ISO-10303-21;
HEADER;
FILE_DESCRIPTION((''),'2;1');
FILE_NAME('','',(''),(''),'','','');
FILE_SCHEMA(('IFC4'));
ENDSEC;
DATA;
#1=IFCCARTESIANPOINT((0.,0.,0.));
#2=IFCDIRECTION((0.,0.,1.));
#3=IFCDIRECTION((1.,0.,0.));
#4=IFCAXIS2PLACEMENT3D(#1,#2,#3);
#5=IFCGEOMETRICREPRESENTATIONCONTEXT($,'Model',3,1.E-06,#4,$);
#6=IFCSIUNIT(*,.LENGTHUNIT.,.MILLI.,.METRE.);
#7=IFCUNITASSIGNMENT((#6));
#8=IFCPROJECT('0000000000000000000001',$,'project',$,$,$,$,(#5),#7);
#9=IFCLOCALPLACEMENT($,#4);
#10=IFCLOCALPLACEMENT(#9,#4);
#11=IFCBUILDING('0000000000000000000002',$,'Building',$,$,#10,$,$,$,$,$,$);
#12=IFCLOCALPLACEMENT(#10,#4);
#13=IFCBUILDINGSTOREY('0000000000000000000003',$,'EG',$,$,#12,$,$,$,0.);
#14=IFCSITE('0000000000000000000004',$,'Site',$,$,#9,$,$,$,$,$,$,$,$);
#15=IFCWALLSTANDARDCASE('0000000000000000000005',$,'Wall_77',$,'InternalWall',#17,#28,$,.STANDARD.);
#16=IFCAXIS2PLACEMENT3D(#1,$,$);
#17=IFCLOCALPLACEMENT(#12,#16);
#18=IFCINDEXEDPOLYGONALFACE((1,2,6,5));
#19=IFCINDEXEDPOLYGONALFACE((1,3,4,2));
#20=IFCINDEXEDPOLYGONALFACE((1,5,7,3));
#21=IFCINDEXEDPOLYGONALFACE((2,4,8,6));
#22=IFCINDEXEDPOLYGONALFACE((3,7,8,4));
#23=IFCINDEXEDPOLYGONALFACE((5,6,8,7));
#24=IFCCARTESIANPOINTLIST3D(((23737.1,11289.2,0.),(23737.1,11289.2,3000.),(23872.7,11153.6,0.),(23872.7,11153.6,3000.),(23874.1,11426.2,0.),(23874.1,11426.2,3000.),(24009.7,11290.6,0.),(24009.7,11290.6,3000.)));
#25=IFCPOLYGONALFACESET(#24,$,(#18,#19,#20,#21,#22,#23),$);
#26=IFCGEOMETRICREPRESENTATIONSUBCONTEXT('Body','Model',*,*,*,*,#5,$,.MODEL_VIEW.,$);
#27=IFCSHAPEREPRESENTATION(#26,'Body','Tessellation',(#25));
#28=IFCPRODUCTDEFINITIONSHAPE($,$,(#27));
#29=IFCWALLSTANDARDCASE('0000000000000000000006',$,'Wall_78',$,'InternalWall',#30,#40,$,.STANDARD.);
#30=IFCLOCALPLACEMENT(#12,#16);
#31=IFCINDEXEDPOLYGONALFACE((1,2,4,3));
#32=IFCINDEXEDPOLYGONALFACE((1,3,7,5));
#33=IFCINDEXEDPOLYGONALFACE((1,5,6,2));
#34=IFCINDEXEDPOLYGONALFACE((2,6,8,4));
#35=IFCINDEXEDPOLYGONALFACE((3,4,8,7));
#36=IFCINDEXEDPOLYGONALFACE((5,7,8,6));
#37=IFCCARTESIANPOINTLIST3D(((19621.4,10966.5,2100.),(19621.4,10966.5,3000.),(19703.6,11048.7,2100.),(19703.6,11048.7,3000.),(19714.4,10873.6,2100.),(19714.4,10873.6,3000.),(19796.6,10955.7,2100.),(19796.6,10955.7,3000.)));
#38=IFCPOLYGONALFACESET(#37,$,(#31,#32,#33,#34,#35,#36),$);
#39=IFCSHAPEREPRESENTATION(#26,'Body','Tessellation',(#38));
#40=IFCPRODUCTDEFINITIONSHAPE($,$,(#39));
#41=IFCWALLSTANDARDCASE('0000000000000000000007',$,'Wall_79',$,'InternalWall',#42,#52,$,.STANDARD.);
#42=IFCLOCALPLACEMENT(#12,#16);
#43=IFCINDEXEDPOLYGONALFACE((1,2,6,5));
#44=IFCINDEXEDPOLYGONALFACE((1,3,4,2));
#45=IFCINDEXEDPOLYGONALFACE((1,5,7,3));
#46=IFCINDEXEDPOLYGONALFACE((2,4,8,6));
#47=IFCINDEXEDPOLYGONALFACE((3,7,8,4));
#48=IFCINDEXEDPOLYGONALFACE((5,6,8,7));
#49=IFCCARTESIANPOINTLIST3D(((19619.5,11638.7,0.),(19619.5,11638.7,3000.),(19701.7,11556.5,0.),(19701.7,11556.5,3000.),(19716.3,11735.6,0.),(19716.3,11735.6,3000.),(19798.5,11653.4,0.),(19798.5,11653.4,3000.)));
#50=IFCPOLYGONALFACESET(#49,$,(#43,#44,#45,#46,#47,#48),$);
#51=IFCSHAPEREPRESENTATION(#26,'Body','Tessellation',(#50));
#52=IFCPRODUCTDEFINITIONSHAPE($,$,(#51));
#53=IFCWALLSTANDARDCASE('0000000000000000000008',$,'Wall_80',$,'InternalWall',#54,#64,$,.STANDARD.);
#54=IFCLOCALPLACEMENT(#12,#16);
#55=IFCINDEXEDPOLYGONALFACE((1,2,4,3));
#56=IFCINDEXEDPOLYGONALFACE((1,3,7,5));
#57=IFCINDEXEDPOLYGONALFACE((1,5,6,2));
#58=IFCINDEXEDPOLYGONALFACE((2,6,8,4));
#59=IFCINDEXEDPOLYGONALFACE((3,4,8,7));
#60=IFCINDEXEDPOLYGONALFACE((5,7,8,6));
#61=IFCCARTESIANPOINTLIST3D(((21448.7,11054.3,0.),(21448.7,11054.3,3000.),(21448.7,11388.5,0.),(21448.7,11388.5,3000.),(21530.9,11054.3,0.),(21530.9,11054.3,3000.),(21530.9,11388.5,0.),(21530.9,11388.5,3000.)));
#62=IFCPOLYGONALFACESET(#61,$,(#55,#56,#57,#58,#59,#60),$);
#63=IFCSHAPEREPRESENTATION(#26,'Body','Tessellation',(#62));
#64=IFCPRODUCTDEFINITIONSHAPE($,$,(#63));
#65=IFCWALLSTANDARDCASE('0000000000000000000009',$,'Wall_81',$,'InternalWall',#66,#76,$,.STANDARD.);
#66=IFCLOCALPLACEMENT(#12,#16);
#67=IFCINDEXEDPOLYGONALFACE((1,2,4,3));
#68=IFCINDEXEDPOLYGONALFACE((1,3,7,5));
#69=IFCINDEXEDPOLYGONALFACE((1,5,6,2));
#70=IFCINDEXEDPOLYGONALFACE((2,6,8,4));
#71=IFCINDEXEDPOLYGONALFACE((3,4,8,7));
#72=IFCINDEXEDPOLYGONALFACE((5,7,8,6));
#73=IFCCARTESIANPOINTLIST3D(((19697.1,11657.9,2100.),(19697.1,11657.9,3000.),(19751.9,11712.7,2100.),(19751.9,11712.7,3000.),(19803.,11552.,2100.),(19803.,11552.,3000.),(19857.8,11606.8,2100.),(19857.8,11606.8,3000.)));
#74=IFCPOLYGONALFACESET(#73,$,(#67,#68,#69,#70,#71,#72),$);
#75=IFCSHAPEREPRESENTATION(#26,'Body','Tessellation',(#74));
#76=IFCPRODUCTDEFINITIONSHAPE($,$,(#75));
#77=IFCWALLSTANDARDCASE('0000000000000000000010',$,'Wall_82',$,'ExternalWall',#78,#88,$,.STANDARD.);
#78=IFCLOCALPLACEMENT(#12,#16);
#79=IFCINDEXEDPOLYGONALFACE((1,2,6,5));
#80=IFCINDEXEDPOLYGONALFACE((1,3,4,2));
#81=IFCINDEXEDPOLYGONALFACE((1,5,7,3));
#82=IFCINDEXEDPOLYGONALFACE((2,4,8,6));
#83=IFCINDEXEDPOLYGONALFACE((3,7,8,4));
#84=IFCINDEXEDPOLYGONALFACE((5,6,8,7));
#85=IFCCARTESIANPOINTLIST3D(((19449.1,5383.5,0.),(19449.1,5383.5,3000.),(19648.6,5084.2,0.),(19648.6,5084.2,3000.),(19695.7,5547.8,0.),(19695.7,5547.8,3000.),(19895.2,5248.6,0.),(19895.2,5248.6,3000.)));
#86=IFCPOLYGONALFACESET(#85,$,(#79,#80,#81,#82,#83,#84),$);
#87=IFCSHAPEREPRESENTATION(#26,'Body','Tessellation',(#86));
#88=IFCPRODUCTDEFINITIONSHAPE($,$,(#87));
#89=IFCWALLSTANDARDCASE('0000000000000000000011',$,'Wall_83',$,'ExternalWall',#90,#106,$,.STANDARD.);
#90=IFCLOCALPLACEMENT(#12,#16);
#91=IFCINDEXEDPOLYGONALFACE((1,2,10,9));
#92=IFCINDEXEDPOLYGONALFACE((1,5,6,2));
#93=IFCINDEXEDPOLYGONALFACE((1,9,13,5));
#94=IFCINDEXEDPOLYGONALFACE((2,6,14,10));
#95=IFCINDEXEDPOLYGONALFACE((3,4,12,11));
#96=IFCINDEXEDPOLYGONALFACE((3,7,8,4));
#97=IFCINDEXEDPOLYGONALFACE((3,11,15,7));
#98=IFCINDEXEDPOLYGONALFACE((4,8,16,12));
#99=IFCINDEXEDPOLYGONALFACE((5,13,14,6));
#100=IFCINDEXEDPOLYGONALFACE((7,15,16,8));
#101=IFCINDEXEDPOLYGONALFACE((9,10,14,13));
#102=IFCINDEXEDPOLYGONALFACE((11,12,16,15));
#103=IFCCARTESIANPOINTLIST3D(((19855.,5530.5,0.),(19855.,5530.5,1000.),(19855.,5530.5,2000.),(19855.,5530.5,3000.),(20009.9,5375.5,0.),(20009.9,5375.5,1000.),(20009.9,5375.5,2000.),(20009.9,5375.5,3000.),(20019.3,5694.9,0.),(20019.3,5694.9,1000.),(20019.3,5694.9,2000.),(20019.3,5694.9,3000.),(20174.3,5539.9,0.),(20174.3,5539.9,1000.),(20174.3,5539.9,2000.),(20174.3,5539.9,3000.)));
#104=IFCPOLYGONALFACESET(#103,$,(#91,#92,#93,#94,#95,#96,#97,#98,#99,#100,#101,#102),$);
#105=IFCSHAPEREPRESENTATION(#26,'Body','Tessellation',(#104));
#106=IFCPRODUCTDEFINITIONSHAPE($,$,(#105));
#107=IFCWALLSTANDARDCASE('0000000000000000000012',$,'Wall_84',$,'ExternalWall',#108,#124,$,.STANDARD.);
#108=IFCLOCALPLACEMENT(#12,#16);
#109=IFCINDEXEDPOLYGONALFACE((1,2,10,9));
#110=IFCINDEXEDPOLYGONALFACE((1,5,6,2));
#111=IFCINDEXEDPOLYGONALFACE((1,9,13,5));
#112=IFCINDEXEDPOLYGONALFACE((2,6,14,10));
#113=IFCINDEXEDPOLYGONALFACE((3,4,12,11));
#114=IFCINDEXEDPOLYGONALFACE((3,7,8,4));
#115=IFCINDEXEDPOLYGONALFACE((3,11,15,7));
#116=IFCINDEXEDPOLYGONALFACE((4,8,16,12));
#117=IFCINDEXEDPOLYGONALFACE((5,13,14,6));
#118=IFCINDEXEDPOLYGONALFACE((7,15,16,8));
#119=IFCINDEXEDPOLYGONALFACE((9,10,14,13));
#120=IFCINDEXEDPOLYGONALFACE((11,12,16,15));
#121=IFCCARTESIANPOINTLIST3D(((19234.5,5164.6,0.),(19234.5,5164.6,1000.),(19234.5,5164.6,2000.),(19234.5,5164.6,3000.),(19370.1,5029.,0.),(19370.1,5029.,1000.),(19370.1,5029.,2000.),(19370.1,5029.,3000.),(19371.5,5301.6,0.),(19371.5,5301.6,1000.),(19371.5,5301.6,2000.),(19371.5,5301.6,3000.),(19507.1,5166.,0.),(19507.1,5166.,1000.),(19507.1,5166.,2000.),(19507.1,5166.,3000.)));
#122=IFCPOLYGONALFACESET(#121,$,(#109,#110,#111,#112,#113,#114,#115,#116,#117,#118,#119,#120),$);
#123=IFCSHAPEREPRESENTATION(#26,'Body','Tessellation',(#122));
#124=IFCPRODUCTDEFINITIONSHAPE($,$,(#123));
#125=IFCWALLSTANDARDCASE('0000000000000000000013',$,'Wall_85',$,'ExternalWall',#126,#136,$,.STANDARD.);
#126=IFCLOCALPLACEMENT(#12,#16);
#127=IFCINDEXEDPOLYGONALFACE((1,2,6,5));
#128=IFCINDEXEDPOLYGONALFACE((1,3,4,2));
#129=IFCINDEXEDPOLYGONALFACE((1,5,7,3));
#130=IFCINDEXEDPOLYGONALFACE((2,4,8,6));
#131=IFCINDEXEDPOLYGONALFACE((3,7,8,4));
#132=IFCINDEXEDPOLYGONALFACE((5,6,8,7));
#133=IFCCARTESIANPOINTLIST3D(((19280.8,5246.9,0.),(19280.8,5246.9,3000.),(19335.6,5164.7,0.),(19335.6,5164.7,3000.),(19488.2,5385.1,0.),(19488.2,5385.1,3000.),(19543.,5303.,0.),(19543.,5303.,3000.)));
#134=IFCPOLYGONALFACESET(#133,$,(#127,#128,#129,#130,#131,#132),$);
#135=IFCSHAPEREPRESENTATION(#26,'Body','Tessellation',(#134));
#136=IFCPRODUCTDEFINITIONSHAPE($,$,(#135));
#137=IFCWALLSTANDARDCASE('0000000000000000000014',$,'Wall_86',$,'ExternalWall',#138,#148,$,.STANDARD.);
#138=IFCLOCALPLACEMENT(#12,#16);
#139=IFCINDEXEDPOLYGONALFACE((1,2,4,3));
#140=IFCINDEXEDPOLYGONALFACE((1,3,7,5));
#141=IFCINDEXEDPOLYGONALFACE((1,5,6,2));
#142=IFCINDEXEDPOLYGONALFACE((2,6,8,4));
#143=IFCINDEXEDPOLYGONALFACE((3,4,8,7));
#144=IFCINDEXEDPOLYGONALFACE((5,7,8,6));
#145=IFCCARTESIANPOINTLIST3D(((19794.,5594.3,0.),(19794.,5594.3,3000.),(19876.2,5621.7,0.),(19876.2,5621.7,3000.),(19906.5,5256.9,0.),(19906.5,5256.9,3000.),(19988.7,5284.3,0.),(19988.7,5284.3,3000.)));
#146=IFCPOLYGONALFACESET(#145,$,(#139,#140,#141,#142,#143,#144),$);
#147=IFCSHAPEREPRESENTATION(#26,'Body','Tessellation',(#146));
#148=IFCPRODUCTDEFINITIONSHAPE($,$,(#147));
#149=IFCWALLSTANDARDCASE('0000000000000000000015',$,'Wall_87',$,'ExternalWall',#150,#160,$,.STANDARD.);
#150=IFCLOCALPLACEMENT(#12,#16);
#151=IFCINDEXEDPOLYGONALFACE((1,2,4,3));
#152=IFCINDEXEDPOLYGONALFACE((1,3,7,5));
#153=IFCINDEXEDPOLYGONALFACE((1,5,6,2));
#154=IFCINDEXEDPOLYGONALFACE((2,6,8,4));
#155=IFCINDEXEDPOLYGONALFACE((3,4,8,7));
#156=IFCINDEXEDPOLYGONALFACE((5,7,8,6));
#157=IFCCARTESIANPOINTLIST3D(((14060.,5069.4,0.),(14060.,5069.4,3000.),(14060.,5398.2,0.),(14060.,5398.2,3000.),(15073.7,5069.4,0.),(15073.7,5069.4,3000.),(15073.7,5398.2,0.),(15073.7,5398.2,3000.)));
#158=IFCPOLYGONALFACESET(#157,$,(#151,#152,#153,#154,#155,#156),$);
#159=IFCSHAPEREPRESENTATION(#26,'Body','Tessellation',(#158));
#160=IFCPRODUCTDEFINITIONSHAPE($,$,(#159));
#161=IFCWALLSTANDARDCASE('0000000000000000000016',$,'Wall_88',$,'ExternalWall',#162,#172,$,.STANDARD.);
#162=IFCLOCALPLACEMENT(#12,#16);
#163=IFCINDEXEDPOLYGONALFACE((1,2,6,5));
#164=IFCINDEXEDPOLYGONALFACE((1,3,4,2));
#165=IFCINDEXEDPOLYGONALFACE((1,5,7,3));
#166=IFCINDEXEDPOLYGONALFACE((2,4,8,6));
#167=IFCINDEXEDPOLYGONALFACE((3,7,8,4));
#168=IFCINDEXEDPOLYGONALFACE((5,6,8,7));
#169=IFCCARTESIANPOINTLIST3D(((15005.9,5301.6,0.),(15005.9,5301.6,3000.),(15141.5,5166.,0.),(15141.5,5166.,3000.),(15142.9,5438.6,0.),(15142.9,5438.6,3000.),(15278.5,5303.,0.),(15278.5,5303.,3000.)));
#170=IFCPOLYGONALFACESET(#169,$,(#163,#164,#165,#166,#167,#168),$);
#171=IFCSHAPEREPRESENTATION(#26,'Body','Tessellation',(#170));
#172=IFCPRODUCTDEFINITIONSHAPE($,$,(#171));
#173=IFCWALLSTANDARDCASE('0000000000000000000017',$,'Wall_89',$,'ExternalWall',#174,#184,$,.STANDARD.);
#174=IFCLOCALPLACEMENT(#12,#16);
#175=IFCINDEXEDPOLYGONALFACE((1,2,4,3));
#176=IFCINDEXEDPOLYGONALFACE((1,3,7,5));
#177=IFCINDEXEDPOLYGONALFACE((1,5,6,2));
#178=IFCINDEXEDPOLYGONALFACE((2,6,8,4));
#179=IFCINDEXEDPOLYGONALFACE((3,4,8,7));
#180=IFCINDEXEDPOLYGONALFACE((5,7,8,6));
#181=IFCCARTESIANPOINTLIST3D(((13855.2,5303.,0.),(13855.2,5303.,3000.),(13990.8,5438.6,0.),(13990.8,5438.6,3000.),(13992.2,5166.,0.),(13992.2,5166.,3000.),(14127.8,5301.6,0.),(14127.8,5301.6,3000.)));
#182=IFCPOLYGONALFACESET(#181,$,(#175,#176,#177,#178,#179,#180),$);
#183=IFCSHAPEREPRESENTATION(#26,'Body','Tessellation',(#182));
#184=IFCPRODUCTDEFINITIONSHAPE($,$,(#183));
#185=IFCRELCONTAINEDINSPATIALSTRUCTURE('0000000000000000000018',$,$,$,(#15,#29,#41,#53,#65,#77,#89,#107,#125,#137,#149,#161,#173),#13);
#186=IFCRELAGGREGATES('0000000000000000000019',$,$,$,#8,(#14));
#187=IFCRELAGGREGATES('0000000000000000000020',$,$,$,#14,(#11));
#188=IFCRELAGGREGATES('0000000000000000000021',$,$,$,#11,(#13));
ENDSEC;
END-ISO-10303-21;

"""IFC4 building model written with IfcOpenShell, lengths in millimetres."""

from ifc_helpers import new_model, si_unit, frame, origin_with_axes, place, context, subcontext, project, spatial, rectangle, extrude, element, save


model = new_model("IFC4")

# Units and contexts
model_context = context("Model", 3, precision=1e-06, world=origin_with_axes())
body_context = subcontext(model_context, "Body", "Model", "MODEL_VIEW")
ifc_project = project(units=[si_unit("LENGTHUNIT", "METRE", prefix="MILLI")], contexts=[model_context])

# Site, building, storey
site_placement = place(None, origin_with_axes())
site = spatial("IfcSite", under=ifc_project, at=site_placement, Name="Site")
building_placement = place(site_placement, origin_with_axes())
building = spatial("IfcBuilding", under=site, at=building_placement, Name="Building")
storey_placement = place(building_placement, origin_with_axes())
storey = spatial("IfcBuildingStorey", under=building, at=storey_placement, Name="EG", Elevation=0.0)

# Wall
wall_1_placement = place(storey_placement, origin_with_axes())
element("IfcWallStandardCase", 1, at=wall_1_placement, inside=storey, Name="Wall_77", ObjectType="InternalWall", PredefinedType="STANDARD", context=body_context, shape_type="SweptSolid", body=[
    extrude(rectangle(XDim=193.7, YDim=191.8), frame((23873.4, 11289.9, 0.0), z_axis=(0.0, 0.0, 1.0), x_axis=(0.707107, 0.707107, 0.0)), (0.0, 0.0, 1.0), 3000.0),
])

# Wall, opening
wall_2_placement = place(storey_placement, origin_with_axes())
wall_2 = element("IfcWallStandardCase", 2, at=wall_2_placement, inside=storey, Name="Wall_78", ObjectType="InternalWall", PredefinedType="STANDARD", context=body_context, shape_type="SweptSolid", body=[
    extrude(rectangle(XDim=116.2, YDim=131.5), frame((19709.0, 10961.1, 0.0), z_axis=(0.0, 0.0, 1.0), x_axis=(-0.707107, -0.707107, 0.0)), (0.0, 0.0, 1.0), 3000.0),
])
opening_1_placement = place(wall_2_placement, origin_with_axes())
element("IfcOpeningElement", 3, at=opening_1_placement, inside=storey, cuts=wall_2, context=body_context, shape_type="SweptSolid", body=[
    extrude(rectangle(XDim=450.0, YDim=131.5), frame((19709.0, 10961.1, 0.0), z_axis=(0.0, 0.0, 1.0), x_axis=(-0.707107, -0.707107, 0.0)), (0.0, 0.0, 1.0), 2100.0),
])

# Walls
wall_3_placement = place(storey_placement, origin_with_axes())
element("IfcWallStandardCase", 4, at=wall_3_placement, inside=storey, Name="Wall_79", ObjectType="InternalWall", PredefinedType="STANDARD", context=body_context, shape_type="SweptSolid", body=[
    extrude(rectangle(XDim=116.2, YDim=137.0), frame((19709.0, 11646.1, 0.0), z_axis=(0.0, 0.0, 1.0), x_axis=(-0.707107, 0.707107, 0.0)), (0.0, 0.0, 1.0), 3000.0),
])
wall_4_placement = place(storey_placement, origin_with_axes())
element("IfcWallStandardCase", 5, at=wall_4_placement, inside=storey, Name="Wall_80", ObjectType="InternalWall", PredefinedType="STANDARD", context=body_context, shape_type="SweptSolid", body=[
    extrude(rectangle(XDim=82.2, YDim=334.2), frame((21489.8, 11221.4, 0.0), z_axis=(0.0, 0.0, 1.0), x_axis=(-1.0, 0.0, 0.0)), (0.0, 0.0, 1.0), 3000.0),
])

# Wall, opening
wall_5_placement = place(storey_placement, origin_with_axes())
wall_5 = element("IfcWallStandardCase", 6, at=wall_5_placement, inside=storey, Name="Wall_81", ObjectType="InternalWall", PredefinedType="STANDARD", context=body_context, shape_type="SweptSolid", body=[
    extrude(rectangle(XDim=77.5, YDim=149.8), frame((19777.5, 11632.4, 0.0), z_axis=(0.0, 0.0, 1.0), x_axis=(0.707107, 0.707107, 0.0)), (0.0, 0.0, 1.0), 3000.0),
])
opening_2_placement = place(wall_5_placement, origin_with_axes())
element("IfcOpeningElement", 7, at=opening_2_placement, inside=storey, cuts=wall_5, context=body_context, shape_type="SweptSolid", body=[
    extrude(rectangle(XDim=450.0, YDim=149.8), frame((19777.5, 11632.4, 0.0), z_axis=(0.0, 0.0, 1.0), x_axis=(0.707107, 0.707107, 0.0)), (0.0, 0.0, 1.0), 2100.0),
])

# Wall
wall_6_placement = place(storey_placement, origin_with_axes())
element("IfcWallStandardCase", 8, at=wall_6_placement, inside=storey, Name="Wall_82", ObjectType="ExternalWall", PredefinedType="STANDARD", context=body_context, shape_type="SweptSolid", body=[
    extrude(rectangle(XDim=296.3, YDim=359.7), frame((19672.2, 5316.0, 0.0), z_axis=(0.0, 0.0, 1.0), x_axis=(-0.83205, -0.5547, 0.0)), (0.0, 0.0, 1.0), 3000.0),
])

# Walls, openings
wall_7_placement = place(storey_placement, origin_with_axes())
wall_7 = element("IfcWallStandardCase", 9, at=wall_7_placement, inside=storey, Name="Wall_83", ObjectType="ExternalWall", PredefinedType="STANDARD", context=body_context, shape_type="SweptSolid", body=[
    extrude(rectangle(XDim=232.5, YDim=219.2), frame((20014.6, 5535.2, 0.0), z_axis=(0.0, 0.0, 1.0), x_axis=(-0.707107, -0.707107, 0.0)), (0.0, 0.0, 1.0), 3000.0),
])
opening_3_placement = place(wall_7_placement, origin_with_axes())
element("IfcOpeningElement", 10, at=opening_3_placement, inside=storey, cuts=wall_7, context=body_context, shape_type="SweptSolid", body=[
    extrude(rectangle(XDim=600.0, YDim=219.2), frame((20052.9, 5573.5, 1000.0), z_axis=(0.0, 0.0, 1.0), x_axis=(-0.707107, -0.707107, 0.0)), (0.0, 0.0, 1.0), 1000.0),
])
wall_8_placement = place(storey_placement, origin_with_axes())
wall_8 = element("IfcWallStandardCase", 11, at=wall_8_placement, inside=storey, Name="Wall_84", ObjectType="ExternalWall", PredefinedType="STANDARD", context=body_context, shape_type="SweptSolid", body=[
    extrude(rectangle(XDim=193.7, YDim=191.8), frame((19370.8, 5165.3, 0.0), z_axis=(0.0, 0.0, 1.0), x_axis=(-0.707107, -0.707107, 0.0)), (0.0, 0.0, 1.0), 3000.0),
])
opening_4_placement = place(wall_8_placement, origin_with_axes())
element("IfcOpeningElement", 12, at=opening_4_placement, inside=storey, cuts=wall_8, context=body_context, shape_type="SweptSolid", body=[
    extrude(rectangle(XDim=600.0, YDim=191.8), frame((19352.1, 5146.7, 1000.0), z_axis=(0.0, 0.0, 1.0), x_axis=(-0.707107, -0.707107, 0.0)), (0.0, 0.0, 1.0), 1000.0),
])

# Walls
wall_9_placement = place(storey_placement, origin_with_axes())
element("IfcWallStandardCase", 13, at=wall_9_placement, inside=storey, Name="Wall_85", ObjectType="ExternalWall", PredefinedType="STANDARD", context=body_context, shape_type="SweptSolid", body=[
    extrude(rectangle(XDim=98.8, YDim=249.3), frame((19411.9, 5274.9, 0.0), z_axis=(0.0, 0.0, 1.0), x_axis=(-0.5547, 0.83205, 0.0)), (0.0, 0.0, 1.0), 3000.0),
])
wall_10_placement = place(storey_placement, origin_with_axes())
element("IfcWallStandardCase", 14, at=wall_10_placement, inside=storey, Name="Wall_86", ObjectType="ExternalWall", PredefinedType="STANDARD", context=body_context, shape_type="SweptSolid", body=[
    extrude(rectangle(XDim=86.6, YDim=355.7), frame((19891.4, 5439.3, 0.0), z_axis=(0.0, 0.0, 1.0), x_axis=(-0.948683, -0.316228, 0.0)), (0.0, 0.0, 1.0), 3000.0),
])
wall_11_placement = place(storey_placement, origin_with_axes())
element("IfcWallStandardCase", 15, at=wall_11_placement, inside=storey, Name="Wall_87", ObjectType="ExternalWall", PredefinedType="STANDARD", context=body_context, shape_type="SweptSolid", body=[
    extrude(rectangle(XDim=1013.7, YDim=328.8), frame((14566.9, 5233.8, 0.0), z_axis=(0.0, 0.0, 1.0), x_axis=(-1.0, 0.0, 0.0)), (0.0, 0.0, 1.0), 3000.0),
])
wall_12_placement = place(storey_placement, origin_with_axes())
element("IfcWallStandardCase", 16, at=wall_12_placement, inside=storey, Name="Wall_88", ObjectType="ExternalWall", PredefinedType="STANDARD", context=body_context, shape_type="SweptSolid", body=[
    extrude(rectangle(XDim=193.7, YDim=191.8), frame((15142.2, 5302.3, 0.0), z_axis=(0.0, 0.0, 1.0), x_axis=(0.707107, 0.707107, 0.0)), (0.0, 0.0, 1.0), 3000.0),
])
wall_13_placement = place(storey_placement, origin_with_axes())
element("IfcWallStandardCase", 17, at=wall_13_placement, inside=storey, Name="Wall_89", ObjectType="ExternalWall", PredefinedType="STANDARD", context=body_context, shape_type="SweptSolid", body=[
    extrude(rectangle(XDim=193.7, YDim=191.8), frame((13991.5, 5302.3, 0.0), z_axis=(0.0, 0.0, 1.0), x_axis=(-0.707107, 0.707107, 0.0)), (0.0, 0.0, 1.0), 3000.0),
])

save(model, "model.ifc")
